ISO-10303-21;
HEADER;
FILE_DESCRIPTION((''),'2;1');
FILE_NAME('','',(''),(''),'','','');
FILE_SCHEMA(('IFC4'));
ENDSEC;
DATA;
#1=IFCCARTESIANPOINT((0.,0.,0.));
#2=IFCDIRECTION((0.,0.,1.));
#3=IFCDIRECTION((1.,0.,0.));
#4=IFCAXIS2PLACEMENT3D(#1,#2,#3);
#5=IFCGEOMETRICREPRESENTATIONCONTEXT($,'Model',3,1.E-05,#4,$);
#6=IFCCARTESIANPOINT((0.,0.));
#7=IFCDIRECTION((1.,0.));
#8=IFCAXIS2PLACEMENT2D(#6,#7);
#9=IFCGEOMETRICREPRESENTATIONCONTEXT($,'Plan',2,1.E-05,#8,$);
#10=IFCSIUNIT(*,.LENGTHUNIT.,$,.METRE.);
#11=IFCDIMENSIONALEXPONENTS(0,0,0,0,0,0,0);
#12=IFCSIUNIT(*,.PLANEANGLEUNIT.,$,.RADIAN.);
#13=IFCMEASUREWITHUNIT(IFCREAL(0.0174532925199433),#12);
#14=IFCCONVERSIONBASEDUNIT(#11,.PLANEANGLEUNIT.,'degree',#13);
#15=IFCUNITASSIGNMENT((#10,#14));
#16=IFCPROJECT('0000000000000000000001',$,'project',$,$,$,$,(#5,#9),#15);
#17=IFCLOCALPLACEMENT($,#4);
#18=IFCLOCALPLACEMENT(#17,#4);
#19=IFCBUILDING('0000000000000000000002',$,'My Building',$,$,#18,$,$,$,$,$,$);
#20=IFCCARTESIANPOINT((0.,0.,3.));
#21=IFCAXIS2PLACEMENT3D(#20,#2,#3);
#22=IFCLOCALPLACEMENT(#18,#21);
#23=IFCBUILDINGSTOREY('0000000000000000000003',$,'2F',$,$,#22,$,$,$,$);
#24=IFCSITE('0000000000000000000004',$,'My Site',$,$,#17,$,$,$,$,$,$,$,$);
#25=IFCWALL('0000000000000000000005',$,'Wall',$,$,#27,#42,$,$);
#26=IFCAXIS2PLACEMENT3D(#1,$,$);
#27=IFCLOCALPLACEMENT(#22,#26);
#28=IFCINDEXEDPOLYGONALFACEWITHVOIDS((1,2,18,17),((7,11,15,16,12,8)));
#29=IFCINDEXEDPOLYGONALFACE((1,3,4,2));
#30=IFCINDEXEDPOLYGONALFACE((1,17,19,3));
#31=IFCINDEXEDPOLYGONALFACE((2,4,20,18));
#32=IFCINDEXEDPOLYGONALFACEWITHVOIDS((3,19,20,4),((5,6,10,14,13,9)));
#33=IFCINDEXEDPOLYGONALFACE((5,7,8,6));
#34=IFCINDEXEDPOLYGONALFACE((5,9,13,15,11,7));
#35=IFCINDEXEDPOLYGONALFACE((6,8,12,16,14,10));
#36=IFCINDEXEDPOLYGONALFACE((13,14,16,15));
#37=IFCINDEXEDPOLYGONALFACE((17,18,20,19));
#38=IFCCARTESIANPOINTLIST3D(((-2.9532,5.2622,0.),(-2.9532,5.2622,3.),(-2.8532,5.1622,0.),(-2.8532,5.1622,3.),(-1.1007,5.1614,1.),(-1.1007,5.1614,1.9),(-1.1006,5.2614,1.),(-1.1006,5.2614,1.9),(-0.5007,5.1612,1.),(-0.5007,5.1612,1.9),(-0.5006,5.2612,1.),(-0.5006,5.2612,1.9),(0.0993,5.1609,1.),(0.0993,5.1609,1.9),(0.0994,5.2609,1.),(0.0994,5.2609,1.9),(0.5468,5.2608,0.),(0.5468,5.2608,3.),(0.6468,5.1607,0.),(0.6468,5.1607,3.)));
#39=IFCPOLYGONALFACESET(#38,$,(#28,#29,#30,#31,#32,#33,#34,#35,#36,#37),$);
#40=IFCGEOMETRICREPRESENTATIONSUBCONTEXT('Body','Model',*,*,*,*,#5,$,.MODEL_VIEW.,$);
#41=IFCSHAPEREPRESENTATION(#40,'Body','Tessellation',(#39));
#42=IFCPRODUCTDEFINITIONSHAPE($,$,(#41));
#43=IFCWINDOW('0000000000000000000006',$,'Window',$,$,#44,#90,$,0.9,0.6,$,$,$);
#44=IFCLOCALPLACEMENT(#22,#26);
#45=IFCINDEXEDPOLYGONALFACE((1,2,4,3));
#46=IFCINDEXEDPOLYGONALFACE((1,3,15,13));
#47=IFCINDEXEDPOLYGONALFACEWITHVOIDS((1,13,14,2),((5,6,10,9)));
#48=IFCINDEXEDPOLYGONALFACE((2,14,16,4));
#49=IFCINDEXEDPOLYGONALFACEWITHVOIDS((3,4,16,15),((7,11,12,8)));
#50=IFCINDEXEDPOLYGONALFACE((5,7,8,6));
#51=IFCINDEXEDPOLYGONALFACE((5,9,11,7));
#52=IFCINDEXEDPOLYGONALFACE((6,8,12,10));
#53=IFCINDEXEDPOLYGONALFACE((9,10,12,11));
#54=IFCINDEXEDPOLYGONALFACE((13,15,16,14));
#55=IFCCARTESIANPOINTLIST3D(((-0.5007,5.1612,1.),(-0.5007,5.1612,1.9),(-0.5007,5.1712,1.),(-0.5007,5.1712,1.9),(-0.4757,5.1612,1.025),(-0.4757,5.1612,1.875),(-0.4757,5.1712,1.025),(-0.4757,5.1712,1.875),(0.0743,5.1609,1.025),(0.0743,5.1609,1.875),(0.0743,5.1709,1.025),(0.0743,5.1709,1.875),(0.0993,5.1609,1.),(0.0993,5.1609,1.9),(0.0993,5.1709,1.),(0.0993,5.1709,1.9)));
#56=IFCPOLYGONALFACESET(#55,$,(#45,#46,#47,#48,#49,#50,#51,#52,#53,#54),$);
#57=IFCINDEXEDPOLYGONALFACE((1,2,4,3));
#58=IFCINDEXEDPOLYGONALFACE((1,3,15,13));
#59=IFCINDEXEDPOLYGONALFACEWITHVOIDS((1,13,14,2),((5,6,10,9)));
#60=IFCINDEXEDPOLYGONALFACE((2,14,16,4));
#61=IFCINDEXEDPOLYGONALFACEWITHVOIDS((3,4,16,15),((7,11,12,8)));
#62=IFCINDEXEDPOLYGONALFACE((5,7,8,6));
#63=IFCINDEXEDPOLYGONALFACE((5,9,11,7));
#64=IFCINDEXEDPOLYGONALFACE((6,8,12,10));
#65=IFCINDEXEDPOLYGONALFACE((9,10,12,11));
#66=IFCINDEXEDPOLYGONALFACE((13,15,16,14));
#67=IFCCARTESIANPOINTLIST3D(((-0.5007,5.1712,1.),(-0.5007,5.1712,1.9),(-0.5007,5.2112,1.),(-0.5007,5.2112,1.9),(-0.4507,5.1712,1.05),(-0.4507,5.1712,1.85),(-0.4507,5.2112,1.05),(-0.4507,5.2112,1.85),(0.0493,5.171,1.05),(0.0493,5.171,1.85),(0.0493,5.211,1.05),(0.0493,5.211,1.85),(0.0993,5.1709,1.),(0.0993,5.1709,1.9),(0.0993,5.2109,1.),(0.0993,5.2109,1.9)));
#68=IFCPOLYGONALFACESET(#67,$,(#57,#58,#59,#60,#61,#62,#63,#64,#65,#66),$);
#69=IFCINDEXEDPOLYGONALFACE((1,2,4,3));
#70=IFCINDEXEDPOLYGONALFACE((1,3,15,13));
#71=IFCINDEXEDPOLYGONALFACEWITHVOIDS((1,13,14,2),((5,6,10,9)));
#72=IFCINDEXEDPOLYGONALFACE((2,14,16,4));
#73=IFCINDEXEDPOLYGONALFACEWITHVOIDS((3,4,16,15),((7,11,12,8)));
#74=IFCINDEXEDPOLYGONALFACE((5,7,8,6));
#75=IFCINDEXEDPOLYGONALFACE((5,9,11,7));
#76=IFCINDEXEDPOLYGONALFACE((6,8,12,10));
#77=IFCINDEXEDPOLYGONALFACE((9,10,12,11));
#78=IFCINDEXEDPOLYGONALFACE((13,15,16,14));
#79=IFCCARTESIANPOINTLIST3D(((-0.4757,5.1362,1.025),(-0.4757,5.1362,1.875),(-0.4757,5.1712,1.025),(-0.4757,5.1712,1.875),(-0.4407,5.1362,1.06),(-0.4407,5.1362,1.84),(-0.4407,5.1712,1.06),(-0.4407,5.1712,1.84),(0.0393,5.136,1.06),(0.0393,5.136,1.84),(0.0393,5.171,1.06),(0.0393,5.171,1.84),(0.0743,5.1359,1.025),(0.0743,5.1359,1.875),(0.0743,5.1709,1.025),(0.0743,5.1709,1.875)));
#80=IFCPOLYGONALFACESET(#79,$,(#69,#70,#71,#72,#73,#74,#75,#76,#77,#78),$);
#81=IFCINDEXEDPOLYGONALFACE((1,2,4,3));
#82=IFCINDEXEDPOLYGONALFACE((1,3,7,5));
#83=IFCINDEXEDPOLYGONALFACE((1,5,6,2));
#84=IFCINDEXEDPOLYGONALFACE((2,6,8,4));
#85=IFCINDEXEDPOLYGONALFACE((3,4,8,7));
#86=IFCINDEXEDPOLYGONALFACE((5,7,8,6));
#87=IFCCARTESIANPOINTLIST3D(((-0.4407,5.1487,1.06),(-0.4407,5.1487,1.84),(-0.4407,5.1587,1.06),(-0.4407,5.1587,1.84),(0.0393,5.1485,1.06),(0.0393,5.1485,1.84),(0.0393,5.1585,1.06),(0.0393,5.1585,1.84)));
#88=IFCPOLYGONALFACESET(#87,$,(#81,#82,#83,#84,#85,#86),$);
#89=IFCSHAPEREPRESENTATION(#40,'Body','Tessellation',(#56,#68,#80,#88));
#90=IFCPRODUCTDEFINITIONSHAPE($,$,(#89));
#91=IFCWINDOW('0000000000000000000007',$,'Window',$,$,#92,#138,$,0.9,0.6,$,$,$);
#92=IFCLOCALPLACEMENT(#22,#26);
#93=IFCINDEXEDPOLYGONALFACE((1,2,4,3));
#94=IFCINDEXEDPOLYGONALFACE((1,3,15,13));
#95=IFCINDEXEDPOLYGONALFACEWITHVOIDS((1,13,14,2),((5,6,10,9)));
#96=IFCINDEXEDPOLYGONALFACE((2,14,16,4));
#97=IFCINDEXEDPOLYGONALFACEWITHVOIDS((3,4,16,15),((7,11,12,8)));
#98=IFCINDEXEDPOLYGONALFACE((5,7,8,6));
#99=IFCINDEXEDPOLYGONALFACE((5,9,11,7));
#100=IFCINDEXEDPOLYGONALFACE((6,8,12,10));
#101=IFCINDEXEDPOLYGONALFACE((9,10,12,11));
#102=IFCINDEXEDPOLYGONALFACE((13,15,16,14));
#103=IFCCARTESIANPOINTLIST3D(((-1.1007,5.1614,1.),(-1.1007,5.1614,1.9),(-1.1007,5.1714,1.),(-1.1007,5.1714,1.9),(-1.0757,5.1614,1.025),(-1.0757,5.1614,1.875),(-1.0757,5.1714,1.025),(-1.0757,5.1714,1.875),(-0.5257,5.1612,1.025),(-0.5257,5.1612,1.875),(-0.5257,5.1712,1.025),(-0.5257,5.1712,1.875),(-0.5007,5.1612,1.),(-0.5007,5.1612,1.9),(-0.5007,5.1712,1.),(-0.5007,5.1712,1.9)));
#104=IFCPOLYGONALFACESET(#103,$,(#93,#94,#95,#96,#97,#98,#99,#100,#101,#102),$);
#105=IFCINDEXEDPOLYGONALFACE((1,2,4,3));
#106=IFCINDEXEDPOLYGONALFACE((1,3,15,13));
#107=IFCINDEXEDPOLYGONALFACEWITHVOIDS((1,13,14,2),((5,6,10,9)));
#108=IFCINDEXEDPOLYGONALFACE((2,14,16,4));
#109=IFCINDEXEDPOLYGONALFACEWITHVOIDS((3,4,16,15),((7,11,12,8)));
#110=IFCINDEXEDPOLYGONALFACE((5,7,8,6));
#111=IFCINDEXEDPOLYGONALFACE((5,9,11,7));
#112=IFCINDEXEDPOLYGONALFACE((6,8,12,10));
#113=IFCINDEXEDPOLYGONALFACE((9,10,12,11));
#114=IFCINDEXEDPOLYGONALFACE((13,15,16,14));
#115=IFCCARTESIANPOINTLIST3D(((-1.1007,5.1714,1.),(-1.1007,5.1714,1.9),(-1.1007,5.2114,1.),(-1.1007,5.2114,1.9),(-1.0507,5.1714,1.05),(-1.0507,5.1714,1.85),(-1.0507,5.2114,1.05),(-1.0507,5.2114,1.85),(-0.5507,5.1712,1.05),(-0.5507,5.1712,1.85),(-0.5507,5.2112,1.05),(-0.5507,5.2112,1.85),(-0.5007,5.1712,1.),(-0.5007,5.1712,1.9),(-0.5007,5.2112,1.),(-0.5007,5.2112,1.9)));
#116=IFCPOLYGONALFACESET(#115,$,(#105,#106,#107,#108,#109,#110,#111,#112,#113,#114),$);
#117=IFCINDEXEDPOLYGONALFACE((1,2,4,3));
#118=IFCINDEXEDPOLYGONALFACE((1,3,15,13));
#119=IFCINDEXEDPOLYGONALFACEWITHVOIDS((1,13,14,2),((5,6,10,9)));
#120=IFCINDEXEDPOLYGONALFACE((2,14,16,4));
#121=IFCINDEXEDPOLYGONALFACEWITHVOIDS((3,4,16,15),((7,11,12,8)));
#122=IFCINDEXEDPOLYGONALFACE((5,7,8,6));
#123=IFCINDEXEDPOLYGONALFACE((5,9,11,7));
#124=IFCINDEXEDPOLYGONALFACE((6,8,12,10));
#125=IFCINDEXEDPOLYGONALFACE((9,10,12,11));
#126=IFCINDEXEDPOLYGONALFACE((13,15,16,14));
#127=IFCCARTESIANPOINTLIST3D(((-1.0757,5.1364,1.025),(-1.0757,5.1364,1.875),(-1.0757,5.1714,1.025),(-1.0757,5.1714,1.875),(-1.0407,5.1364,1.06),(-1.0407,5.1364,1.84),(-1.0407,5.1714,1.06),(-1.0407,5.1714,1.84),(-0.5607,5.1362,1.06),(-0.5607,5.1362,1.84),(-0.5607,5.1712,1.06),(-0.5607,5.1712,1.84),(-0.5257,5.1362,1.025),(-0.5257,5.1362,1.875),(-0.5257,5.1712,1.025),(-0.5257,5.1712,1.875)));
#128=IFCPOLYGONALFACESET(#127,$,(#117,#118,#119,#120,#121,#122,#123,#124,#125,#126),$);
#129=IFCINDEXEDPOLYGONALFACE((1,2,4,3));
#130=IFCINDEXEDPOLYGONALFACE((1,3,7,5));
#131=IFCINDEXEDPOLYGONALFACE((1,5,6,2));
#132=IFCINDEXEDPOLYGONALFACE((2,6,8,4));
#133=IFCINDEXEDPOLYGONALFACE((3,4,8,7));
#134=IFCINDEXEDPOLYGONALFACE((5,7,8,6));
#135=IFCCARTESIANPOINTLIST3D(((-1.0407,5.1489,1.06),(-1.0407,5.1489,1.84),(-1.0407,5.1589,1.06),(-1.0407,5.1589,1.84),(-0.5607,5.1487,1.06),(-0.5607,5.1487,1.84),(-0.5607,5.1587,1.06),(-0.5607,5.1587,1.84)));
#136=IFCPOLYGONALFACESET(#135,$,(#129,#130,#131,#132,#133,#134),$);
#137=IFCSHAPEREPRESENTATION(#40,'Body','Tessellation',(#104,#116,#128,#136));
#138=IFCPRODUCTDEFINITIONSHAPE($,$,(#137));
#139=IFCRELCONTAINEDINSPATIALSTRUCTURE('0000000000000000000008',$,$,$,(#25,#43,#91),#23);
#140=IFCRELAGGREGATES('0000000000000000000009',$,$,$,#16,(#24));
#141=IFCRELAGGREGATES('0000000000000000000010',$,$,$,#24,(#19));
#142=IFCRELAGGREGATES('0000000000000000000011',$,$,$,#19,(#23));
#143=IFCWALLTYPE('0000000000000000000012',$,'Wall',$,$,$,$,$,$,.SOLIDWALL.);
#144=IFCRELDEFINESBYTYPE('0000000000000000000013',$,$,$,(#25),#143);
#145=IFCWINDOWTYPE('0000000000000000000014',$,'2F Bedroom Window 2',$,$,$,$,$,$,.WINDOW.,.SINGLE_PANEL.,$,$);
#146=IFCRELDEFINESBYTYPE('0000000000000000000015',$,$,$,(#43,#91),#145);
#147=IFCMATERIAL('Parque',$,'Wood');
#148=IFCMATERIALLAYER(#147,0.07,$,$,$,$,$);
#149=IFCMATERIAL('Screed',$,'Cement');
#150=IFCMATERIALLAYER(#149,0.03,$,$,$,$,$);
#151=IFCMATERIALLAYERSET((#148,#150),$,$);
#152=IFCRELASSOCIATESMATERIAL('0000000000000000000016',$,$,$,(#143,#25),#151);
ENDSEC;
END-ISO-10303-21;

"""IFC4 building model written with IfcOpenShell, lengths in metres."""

from ifc_helpers import new_model, entity, si_unit, converted_unit, frame, origin_with_axes, origin_2d_with_axis, place, context, subcontext, project, spatial, line, indexed_curve, outline, extrude, shape, source, transform, mapped, material, layer, layer_set, layer_usage, type_object, type_shapes, element, fill, save


model = new_model("IFC4")

# Units and contexts
model_context = context("Model", 3, precision=1e-05, world=origin_with_axes())
plan_context = context("Plan", 2, precision=1e-05, world=origin_2d_with_axis())
body_context_1 = subcontext(model_context, "Body", "Model", "MODEL_VIEW")
body_context_2 = subcontext(plan_context, "Body", "Plan", "PLAN_VIEW")
ifc_project = project(units=[si_unit("LENGTHUNIT", "METRE"), converted_unit("PLANEANGLEUNIT", "degree", entity("IfcReal", 0.0174532925199433), si_unit("PLANEANGLEUNIT", "RADIAN"), dimensions=[0, 0, 0, 0, 0, 0, 0])], contexts=[model_context, plan_context])

# Site, building, storey
site_placement = place(None, origin_with_axes())
site = spatial("IfcSite", under=ifc_project, at=site_placement, Name="My Site")
building_placement = place(site_placement, origin_with_axes())
building = spatial("IfcBuilding", under=site, at=building_placement, Name="My Building")
storey_placement = place(building_placement, frame((0.0, 0.0, 3.0), z_axis=(0.0, 0.0, 1.0), x_axis=(1.0, 0.0, 0.0)))
storey = spatial("IfcBuildingStorey", under=building, at=storey_placement, Name="2F")

# Shared definitions
ifc_material_1 = material(Name="Parque", Category="Wood")
ifc_layer_1 = layer(ifc_material_1, 0.07)
ifc_material_2 = material(Name="Screed", Category="Cement")
ifc_layer_2 = layer(ifc_material_2, 0.03)
ifc_layer_set = layer_set([ifc_layer_1, ifc_layer_2])
wall_type = type_object("IfcWallType", Name="Wall", PredefinedType="SOLIDWALL", material=ifc_layer_set)

# Wall, openings, windows
ifc_layer_usage_1 = layer_usage(ifc_layer_set, "AXIS2", "POSITIVE", 0.0)
wall_1_placement = place(storey_placement, frame((0.5468, 5.2608, 0.0), z_axis=(0.0, 0.0, 1.0), x_axis=(-1.0, 0.000416, 0.0)))
wall_1 = element("IfcWall", 1, at=wall_1_placement, inside=storey, type_object=wall_type, material=ifc_layer_usage_1, Name="Wall", context=body_context_1, shape_type="SweptSolid", body=[
    extrude(outline(indexed_curve([(0.0, 0.0), (-0.1, 0.1), (3.4, 0.1), (3.5, 0.0)], segments=[line(1, 2, 3, 4, 1)])), origin_with_axes(), (0.0, 0.0, 1.0), 3.0),
])
shared_shape_1 = source(origin_with_axes(), body_context_1, "Body", "SweptSolid", [
    extrude(outline(indexed_curve([(0.0, 0.0), (0.6, 0.0), (0.6, 0.9), (0.0, 0.9)], segments=[line(1, 2, 3, 4, 1)])), frame((0.0, -0.6, 0.0), z_axis=(0.0, -1.0, 0.0), x_axis=(1.0, 0.0, 0.0)), (0.0, 0.0, -1.0), 1.2),
])
opening_1_placement = place(wall_1_placement, frame((0.4475, 0.0, 1.0), z_axis=(0.0, 0.0, 1.0), x_axis=(1.0, 0.0, 0.0)))
opening_1 = element("IfcOpeningElement", 2, at=opening_1_placement, cuts=wall_1, PredefinedType="OPENING", context=body_context_1, shape_type="MappedRepresentation", body=[
    mapped(shared_shape_1, transform((0.0, 0.0, 0.0), x_axis=(1.0, 0.0, 0.0), y_axis=(0.0, 1.0, 0.0), z_axis=(0.0, 0.0, 1.0), scale=1.0)),
])
opening_2_placement = place(wall_1_placement, frame((1.0475, 0.0, 1.0), z_axis=(0.0, 0.0, 1.0), x_axis=(1.0, 0.0, 0.0)))
opening_2 = element("IfcOpeningElement", 3, at=opening_2_placement, cuts=wall_1, PredefinedType="OPENING", context=body_context_1, shape_type="MappedRepresentation", body=[
    mapped(shared_shape_1, transform((0.0, 0.0, 0.0), x_axis=(1.0, 0.0, 0.0), y_axis=(0.0, 1.0, 0.0), z_axis=(0.0, 0.0, 1.0), scale=1.0)),
])
window_type_1 = type_object("IfcWindowType", Name="2F Bedroom Window 2", PartitioningType="SINGLE_PANEL", PredefinedType="WINDOW")
shared_shape_2 = source(origin_with_axes(), body_context_1, "Body", "SweptSolid", [
    extrude(outline(indexed_curve([(0.0, 0.0), (0.6, 0.0), (0.6, 0.9), (0.0, 0.9)], segments=[line(1, 2, 3, 4, 1)]), holes=[indexed_curve([(0.025, 0.025), (0.575, 0.025), (0.575, 0.875), (0.025, 0.875)], segments=[line(1, 2, 3, 4, 1)])]), frame((0.0, 0.09, 0.0), z_axis=(0.0, -1.0, 0.0), x_axis=(1.0, 0.0, 0.0)), (0.0, 0.0, -1.0), 0.01),
    extrude(outline(indexed_curve([(0.0, 0.0), (0.6, 0.0), (0.6, 0.9), (0.0, 0.9)], segments=[line(1, 2, 3, 4, 1)]), holes=[indexed_curve([(0.05, 0.05), (0.55, 0.05), (0.55, 0.85), (0.05, 0.85)], segments=[line(1, 2, 3, 4, 1)])]), frame((0.0, 0.05, 0.0), z_axis=(0.0, -1.0, 0.0), x_axis=(1.0, 0.0, 0.0)), (0.0, 0.0, -1.0), 0.04),
    extrude(outline(indexed_curve([(0.0, 0.0), (0.55, 0.0), (0.55, 0.85), (0.0, 0.85)], segments=[line(1, 2, 3, 4, 1)]), holes=[indexed_curve([(0.035, 0.035), (0.515, 0.035), (0.515, 0.815), (0.035, 0.815)], segments=[line(1, 2, 3, 4, 1)])]), frame((0.025, 0.09, 0.025), z_axis=(0.0, -1.0, 0.0), x_axis=(1.0, 0.0, 0.0)), (0.0, 0.0, -1.0), 0.035),
    extrude(outline(indexed_curve([(0.035, 0.035), (0.515, 0.035), (0.515, 0.815), (0.035, 0.815)], segments=[line(1, 2, 3, 4, 1)])), frame((0.025, 0.1025, 0.025), z_axis=(0.0, -1.0, 0.0), x_axis=(1.0, 0.0, 0.0)), (0.0, 0.0, -1.0), 0.01),
])
shared_shape_3 = source(origin_with_axes(), body_context_2, "Body", "Curve2D", [
    entity("IfcIndexedPolyCurve", entity("IfcCartesianPointList2D", [[0.05, 0.05], [0.55, 0.05]])),
    entity("IfcIndexedPolyCurve", entity("IfcCartesianPointList2D", [[0.0, 0.1], [0.025, 0.1], [0.025, 0.09], [0.05, 0.09], [0.05, 0.05], [0.0, 0.05]]), [entity("IfcLineIndex", [1, 2, 3, 4, 5, 6, 1])]),
    entity("IfcIndexedPolyCurve", entity("IfcCartesianPointList2D", [[0.6, 0.1], [0.575, 0.1], [0.575, 0.09], [0.55, 0.09], [0.55, 0.05], [0.6, 0.05]]), [entity("IfcLineIndex", [1, 2, 3, 4, 5, 6, 1])]),
    entity("IfcIndexedPolyCurve", entity("IfcCartesianPointList2D", [[0.025, 0.09], [0.06, 0.09], [0.06, 0.125], [0.025, 0.125]]), [entity("IfcLineIndex", [1, 2, 3, 4, 1])]),
    entity("IfcIndexedPolyCurve", entity("IfcCartesianPointList2D", [[0.575, 0.09], [0.54, 0.09], [0.54, 0.125], [0.575, 0.125]]), [entity("IfcLineIndex", [1, 2, 3, 4, 1])]),
    entity("IfcIndexedPolyCurve", entity("IfcCartesianPointList2D", [[0.06, 0.09], [0.54, 0.09]])),
    entity("IfcIndexedPolyCurve", entity("IfcCartesianPointList2D", [[0.06, 0.125], [0.54, 0.125]])),
    entity("IfcIndexedPolyCurve", entity("IfcCartesianPointList2D", [[0.06, 0.1075], [0.54, 0.1075]])),
])
type_shapes(window_type_1, [shared_shape_2, shared_shape_3])
window_1_placement = place(opening_1_placement, frame((0.0, 0.0, 0.0), z_axis=(0.0, 0.0, 1.0), x_axis=(1.0, 0.0, 0.0)))
window_1 = element("IfcWindow", 4, at=window_1_placement, inside=storey, type_object=window_type_1, Name="Window", OverallHeight=0.9, OverallWidth=0.6, shapes=[
    shape(body_context_1, "Body", "MappedRepresentation", [mapped(shared_shape_2, transform((0.0, 0.0, 0.0), x_axis=(1.0, 0.0, 0.0), y_axis=(0.0, 1.0, 0.0), z_axis=(0.0, 0.0, 1.0), scale=1.0))]),
    shape(body_context_2, "Body", "MappedRepresentation", [mapped(shared_shape_3, transform((0.0, 0.0, 0.0), x_axis=(1.0, 0.0, 0.0), y_axis=(0.0, 1.0, 0.0), z_axis=(0.0, 0.0, 1.0), scale=1.0))]),
])
fill(opening_1, window_1)
window_2_placement = place(opening_2_placement, frame((0.0, 0.0, 0.0), z_axis=(0.0, 0.0, 1.0), x_axis=(1.0, 0.0, 0.0)))
window_2 = element("IfcWindow", 5, at=window_2_placement, inside=storey, type_object=window_type_1, Name="Window", OverallHeight=0.9, OverallWidth=0.6, shapes=[
    shape(body_context_1, "Body", "MappedRepresentation", [mapped(shared_shape_2, transform((0.0, 0.0, 0.0), x_axis=(1.0, 0.0, 0.0), y_axis=(0.0, 1.0, 0.0), z_axis=(0.0, 0.0, 1.0), scale=1.0))]),
    shape(body_context_2, "Body", "MappedRepresentation", [mapped(shared_shape_3, transform((0.0, 0.0, 0.0), x_axis=(1.0, 0.0, 0.0), y_axis=(0.0, 1.0, 0.0), z_axis=(0.0, 0.0, 1.0), scale=1.0))]),
])
fill(opening_2, window_2)

save(model, "model.ifc")
